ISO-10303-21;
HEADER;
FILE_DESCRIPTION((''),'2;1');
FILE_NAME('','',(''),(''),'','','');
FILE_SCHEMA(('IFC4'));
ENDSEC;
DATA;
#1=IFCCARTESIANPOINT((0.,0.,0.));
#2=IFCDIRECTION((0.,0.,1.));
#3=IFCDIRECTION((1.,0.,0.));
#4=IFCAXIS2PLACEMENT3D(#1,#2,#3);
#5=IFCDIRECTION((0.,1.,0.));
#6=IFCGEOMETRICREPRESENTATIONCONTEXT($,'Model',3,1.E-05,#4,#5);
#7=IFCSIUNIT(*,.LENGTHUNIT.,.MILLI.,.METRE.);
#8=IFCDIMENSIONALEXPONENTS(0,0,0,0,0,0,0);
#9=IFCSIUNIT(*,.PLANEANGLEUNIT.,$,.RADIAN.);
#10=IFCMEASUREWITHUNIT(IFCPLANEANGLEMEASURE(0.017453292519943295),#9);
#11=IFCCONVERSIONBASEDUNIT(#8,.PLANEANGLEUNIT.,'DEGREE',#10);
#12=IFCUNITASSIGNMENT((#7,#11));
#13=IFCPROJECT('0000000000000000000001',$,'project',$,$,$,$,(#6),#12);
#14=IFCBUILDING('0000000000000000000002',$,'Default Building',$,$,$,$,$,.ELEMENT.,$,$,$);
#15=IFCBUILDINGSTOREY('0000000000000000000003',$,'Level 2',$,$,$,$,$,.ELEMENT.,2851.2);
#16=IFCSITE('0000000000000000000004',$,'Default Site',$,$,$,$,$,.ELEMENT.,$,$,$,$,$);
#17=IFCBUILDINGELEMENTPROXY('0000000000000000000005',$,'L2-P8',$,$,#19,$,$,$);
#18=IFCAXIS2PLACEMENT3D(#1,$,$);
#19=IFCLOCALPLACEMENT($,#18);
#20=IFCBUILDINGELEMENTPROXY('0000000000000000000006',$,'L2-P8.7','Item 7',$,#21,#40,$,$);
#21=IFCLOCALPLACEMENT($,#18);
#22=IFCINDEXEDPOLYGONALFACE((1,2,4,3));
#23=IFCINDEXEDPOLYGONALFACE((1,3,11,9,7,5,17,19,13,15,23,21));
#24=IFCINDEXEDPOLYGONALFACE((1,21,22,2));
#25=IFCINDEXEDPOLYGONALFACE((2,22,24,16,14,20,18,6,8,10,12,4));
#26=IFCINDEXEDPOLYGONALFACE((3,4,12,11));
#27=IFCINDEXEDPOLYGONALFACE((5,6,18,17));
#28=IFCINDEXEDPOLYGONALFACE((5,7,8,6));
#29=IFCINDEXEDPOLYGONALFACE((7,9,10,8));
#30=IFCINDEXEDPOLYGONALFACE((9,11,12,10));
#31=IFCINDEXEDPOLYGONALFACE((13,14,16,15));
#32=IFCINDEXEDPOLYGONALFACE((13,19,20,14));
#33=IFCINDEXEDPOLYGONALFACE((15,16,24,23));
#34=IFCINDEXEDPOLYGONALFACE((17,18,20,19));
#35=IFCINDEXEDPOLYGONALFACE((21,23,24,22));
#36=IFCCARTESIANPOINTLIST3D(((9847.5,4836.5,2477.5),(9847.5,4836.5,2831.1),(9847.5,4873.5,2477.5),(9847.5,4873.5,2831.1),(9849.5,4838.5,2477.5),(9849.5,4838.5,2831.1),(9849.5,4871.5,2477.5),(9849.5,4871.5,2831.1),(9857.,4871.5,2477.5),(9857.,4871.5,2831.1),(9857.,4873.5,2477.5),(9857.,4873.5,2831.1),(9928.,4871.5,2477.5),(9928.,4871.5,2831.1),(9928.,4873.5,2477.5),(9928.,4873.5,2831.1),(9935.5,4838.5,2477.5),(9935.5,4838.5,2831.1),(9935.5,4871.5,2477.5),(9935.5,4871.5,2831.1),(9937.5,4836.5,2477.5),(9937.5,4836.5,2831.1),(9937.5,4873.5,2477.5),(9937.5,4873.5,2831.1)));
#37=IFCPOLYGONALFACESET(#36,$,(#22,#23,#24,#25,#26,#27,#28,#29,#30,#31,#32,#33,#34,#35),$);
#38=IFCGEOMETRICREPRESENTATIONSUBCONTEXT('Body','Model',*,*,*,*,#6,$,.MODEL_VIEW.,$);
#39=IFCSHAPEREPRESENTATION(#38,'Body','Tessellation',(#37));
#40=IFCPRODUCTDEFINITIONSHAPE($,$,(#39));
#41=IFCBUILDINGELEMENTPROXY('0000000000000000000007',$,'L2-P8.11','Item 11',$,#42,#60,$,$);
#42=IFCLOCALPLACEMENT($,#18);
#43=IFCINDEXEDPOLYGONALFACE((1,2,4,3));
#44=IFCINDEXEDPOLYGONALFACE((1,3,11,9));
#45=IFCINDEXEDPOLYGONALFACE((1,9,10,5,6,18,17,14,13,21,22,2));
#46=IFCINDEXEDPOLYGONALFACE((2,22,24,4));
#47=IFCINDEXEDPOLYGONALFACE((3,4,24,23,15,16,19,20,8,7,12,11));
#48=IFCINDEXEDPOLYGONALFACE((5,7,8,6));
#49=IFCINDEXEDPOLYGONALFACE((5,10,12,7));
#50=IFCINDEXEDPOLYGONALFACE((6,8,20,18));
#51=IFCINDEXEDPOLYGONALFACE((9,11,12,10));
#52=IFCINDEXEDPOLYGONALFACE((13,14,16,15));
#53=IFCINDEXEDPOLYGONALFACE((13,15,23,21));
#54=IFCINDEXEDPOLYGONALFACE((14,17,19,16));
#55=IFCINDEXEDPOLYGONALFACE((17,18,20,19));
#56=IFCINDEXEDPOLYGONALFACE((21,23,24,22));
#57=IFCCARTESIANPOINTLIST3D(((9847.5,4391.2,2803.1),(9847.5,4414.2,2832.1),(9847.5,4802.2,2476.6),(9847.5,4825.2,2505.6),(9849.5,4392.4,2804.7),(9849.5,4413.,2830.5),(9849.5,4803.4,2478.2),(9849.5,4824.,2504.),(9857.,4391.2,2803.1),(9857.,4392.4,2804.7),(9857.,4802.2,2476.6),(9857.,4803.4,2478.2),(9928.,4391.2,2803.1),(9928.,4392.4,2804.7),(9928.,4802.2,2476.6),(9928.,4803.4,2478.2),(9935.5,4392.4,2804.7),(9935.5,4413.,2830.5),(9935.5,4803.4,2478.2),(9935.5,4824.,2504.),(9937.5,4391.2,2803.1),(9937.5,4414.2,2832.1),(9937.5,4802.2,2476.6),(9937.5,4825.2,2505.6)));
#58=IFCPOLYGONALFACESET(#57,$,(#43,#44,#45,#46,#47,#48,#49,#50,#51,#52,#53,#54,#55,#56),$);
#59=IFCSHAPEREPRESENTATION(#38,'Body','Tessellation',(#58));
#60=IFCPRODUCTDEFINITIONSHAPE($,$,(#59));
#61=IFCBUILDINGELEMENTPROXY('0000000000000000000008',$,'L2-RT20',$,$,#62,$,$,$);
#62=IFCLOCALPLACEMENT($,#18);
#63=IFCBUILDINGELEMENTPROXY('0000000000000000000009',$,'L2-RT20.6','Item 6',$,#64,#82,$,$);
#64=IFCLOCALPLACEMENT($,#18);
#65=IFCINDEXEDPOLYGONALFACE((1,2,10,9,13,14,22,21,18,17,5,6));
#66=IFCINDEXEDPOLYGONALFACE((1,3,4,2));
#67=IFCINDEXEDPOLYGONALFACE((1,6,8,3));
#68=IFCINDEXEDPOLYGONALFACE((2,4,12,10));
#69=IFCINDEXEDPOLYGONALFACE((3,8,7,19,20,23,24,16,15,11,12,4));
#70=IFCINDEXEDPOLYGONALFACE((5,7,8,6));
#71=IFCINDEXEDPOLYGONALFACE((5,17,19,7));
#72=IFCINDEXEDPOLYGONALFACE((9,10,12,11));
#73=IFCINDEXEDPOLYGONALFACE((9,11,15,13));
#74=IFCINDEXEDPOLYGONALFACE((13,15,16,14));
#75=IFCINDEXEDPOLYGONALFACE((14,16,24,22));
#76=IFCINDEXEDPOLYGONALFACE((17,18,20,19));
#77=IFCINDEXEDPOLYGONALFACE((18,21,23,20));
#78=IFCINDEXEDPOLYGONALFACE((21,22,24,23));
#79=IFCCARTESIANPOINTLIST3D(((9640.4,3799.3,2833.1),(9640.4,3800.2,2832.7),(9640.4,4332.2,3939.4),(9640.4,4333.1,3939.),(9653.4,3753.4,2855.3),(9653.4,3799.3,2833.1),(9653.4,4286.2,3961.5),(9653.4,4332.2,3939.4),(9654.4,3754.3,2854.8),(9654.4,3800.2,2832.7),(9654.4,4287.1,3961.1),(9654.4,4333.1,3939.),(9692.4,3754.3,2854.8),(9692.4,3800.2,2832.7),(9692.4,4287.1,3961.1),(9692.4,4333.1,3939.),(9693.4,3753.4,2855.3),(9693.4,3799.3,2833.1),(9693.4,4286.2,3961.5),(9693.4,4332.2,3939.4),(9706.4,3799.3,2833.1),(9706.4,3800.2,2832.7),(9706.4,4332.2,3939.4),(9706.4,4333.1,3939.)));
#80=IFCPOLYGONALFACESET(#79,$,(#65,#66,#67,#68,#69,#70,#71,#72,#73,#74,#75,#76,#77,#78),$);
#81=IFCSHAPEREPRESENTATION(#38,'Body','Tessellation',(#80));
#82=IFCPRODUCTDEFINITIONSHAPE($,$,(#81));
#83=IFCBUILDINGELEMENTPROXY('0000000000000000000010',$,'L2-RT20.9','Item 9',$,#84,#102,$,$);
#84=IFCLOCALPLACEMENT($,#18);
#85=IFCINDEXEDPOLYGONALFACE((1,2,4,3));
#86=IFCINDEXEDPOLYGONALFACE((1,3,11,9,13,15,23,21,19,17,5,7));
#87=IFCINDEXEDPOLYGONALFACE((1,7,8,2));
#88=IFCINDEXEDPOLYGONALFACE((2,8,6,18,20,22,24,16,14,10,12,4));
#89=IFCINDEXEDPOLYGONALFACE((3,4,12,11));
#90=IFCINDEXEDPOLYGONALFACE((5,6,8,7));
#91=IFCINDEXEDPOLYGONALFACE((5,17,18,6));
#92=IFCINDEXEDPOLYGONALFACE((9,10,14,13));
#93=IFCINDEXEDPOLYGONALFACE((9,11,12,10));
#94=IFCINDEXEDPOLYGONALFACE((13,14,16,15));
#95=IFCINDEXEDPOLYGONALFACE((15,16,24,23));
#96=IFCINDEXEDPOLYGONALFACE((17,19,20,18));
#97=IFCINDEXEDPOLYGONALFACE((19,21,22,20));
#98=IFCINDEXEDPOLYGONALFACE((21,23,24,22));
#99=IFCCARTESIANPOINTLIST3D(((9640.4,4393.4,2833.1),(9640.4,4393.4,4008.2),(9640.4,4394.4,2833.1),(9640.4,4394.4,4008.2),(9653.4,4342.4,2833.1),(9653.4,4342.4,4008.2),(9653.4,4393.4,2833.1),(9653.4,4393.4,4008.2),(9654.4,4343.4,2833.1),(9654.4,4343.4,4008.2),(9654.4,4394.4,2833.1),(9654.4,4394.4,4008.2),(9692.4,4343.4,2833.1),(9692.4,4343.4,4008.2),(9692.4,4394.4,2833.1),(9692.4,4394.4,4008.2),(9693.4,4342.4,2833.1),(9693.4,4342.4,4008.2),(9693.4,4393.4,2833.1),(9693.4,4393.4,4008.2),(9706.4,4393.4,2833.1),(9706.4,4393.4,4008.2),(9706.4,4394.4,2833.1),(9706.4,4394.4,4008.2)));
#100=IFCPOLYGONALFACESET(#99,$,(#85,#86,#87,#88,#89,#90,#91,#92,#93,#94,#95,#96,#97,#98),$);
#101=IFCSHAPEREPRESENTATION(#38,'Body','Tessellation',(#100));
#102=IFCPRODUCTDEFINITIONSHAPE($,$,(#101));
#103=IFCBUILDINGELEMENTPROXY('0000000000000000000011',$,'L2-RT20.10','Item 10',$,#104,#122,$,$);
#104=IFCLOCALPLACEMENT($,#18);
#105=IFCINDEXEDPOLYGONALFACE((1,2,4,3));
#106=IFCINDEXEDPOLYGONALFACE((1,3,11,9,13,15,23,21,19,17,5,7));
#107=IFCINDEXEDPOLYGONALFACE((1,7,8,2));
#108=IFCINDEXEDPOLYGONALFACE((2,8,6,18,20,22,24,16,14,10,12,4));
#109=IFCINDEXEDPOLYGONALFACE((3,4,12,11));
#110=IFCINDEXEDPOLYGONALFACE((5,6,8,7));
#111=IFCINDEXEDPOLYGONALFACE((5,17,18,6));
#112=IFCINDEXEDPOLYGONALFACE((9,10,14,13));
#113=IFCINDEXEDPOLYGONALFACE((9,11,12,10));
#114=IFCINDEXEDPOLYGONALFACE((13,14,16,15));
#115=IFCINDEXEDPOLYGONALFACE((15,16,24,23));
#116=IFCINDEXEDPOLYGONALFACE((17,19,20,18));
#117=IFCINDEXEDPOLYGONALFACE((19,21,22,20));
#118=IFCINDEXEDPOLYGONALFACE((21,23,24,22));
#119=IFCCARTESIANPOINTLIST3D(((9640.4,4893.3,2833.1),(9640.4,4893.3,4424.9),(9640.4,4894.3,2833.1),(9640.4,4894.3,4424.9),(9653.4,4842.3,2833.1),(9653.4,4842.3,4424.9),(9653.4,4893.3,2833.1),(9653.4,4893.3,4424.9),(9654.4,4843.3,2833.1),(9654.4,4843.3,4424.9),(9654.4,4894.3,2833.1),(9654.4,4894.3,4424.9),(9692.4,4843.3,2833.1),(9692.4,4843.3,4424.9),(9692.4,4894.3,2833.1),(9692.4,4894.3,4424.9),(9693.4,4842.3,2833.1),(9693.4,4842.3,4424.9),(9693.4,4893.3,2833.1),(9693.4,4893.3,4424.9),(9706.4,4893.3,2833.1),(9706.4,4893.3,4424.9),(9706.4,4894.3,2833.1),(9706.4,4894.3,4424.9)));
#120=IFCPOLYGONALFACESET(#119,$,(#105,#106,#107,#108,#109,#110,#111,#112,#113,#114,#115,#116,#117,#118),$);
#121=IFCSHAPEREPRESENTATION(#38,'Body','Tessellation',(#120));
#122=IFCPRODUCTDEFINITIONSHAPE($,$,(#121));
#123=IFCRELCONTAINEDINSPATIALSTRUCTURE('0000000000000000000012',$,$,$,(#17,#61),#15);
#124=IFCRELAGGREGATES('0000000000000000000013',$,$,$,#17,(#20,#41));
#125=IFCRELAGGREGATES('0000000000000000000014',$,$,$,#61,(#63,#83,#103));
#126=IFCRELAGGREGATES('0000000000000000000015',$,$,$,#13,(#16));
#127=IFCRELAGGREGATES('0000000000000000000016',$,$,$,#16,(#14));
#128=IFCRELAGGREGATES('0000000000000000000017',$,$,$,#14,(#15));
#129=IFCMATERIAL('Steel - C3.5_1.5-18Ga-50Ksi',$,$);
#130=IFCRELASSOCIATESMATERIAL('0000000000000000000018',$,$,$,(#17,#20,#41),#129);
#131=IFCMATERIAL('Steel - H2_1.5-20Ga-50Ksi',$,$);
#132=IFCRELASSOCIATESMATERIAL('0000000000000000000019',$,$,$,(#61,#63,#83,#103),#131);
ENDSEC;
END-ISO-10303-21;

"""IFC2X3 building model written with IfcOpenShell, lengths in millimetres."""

from ifc_helpers import new_model, entity, si_unit, converted_unit, direction, frame, origin, origin_with_axes, origin_2d_with_axis, place, context, subcontext, project, spatial, polyline, c_section, outline, extrude, material, element, aggregate, save


model = new_model("IFC2X3")

# Units and contexts
model_context = context("Model", 3, precision=1e-05, world=origin_with_axes(), true_north=direction((0.0, 1.0, 0.0)))
body_context = subcontext(model_context, "Body", "Model", "MODEL_VIEW")
ifc_project = project(units=[si_unit("LENGTHUNIT", "METRE", prefix="MILLI"), converted_unit("PLANEANGLEUNIT", "DEGREE", entity("IfcPlaneAngleMeasure", 0.017453292519943295), si_unit("PLANEANGLEUNIT", "RADIAN"), dimensions=[0, 0, 0, 0, 0, 0, 0])], contexts=[model_context])

# Site, building, storey
site = spatial("IfcSite", under=ifc_project, Name="Default Site", CompositionType="ELEMENT")
building = spatial("IfcBuilding", under=site, Name="Default Building", CompositionType="ELEMENT")
storey = spatial("IfcBuildingStorey", under=building, Name="Level 2", CompositionType="ELEMENT", Elevation=2851.2)

# Building element proxies
ifc_material_1 = material(Name="Steel - C3.5_1.5-18Ga-50Ksi")
proxy_1 = element("IfcBuildingElementProxy", 1, inside=storey, material=ifc_material_1, Name="L2-P8")
proxy_2_placement = place(None, frame((9892.5, 4855.0, 2477.5), z_axis=(0.0, 0.0, 1.0), x_axis=(0.0, 37.0, 0.0)))
proxy_2 = element("IfcBuildingElementProxy", 2, at=proxy_2_placement, material=ifc_material_1, Name="L2-P8.7", Description="Item 7", context=body_context, shape_type="SweptSolid", body=[
    extrude(c_section(Depth=90.0, Width=37.0, WallThickness=2.0, Girth=9.5, at=origin_2d_with_axis()), origin(), (0.0, 0.0, 1.0), 353.6),
])
proxy_3_placement = place(None, frame((9892.5, 4402.7, 2817.6), z_axis=(0.0, 0.783, -0.622), x_axis=(0.0, -23.026, -28.962)))
proxy_3 = element("IfcBuildingElementProxy", 3, at=proxy_3_placement, material=ifc_material_1, Name="L2-P8.11", Description="Item 11", context=body_context, shape_type="SweptSolid", body=[
    extrude(c_section(Depth=90.0, Width=37.0, WallThickness=2.0, Girth=9.5, at=origin_2d_with_axis()), origin(), (0.0, 0.0, 1.0), 524.9),
])
aggregate(proxy_1, [proxy_2, proxy_3])
ifc_material_2 = material(Name="Steel - H2_1.5-20Ga-50Ksi")
proxy_4 = element("IfcBuildingElementProxy", 4, inside=storey, material=ifc_material_2, Name="L2-RT20")
proxy_5_placement = place(None, frame((9706.4, 3800.2, 2832.7), z_axis=(0.0, 0.434, 0.901), x_axis=(-40.0, 0.0, 0.0)))
proxy_5 = element("IfcBuildingElementProxy", 5, at=proxy_5_placement, material=ifc_material_2, Name="L2-RT20.6", Description="Item 6", context=body_context, shape_type="SweptSolid", body=[
    extrude(outline(polyline([(0.0, 0.0), (14.0, 0.0), (14.0, 51.0), (52.0, 51.0), (52.0, 0.0), (66.0, 0.0), (66.0, 1.0), (53.0, 1.0), (53.0, 52.0), (13.0, 52.0), (13.0, 1.0), (0.0, 1.0), (0.0, 0.0)])), origin(), (0.0, 0.0, 1.0), 1227.9),
])
proxy_6_placement = place(None, frame((9706.4, 4394.4, 2833.1), z_axis=(0.0, 0.0, 1.0), x_axis=(-40.0, 0.0, 0.0)))
proxy_6 = element("IfcBuildingElementProxy", 6, at=proxy_6_placement, material=ifc_material_2, Name="L2-RT20.9", Description="Item 9", context=body_context, shape_type="SweptSolid", body=[
    extrude(outline(polyline([(0.0, 0.0), (14.0, 0.0), (14.0, 51.0), (52.0, 51.0), (52.0, 0.0), (66.0, 0.0), (66.0, 1.0), (53.0, 1.0), (53.0, 52.0), (13.0, 52.0), (13.0, 1.0), (0.0, 1.0), (0.0, 0.0)])), origin(), (0.0, 0.0, 1.0), 1175.1),
])
proxy_7_placement = place(None, frame((9706.4, 4894.3, 2833.1), z_axis=(0.0, 0.0, 1.0), x_axis=(-40.0, 0.0, 0.0)))
proxy_7 = element("IfcBuildingElementProxy", 7, at=proxy_7_placement, material=ifc_material_2, Name="L2-RT20.10", Description="Item 10", context=body_context, shape_type="SweptSolid", body=[
    extrude(outline(polyline([(0.0, 0.0), (14.0, 0.0), (14.0, 51.0), (52.0, 51.0), (52.0, 0.0), (66.0, 0.0), (66.0, 1.0), (53.0, 1.0), (53.0, 52.0), (13.0, 52.0), (13.0, 1.0), (0.0, 1.0), (0.0, 0.0)])), origin(), (0.0, 0.0, 1.0), 1591.8),
])
aggregate(proxy_4, [proxy_5, proxy_6, proxy_7])

save(model, "model.ifc")
